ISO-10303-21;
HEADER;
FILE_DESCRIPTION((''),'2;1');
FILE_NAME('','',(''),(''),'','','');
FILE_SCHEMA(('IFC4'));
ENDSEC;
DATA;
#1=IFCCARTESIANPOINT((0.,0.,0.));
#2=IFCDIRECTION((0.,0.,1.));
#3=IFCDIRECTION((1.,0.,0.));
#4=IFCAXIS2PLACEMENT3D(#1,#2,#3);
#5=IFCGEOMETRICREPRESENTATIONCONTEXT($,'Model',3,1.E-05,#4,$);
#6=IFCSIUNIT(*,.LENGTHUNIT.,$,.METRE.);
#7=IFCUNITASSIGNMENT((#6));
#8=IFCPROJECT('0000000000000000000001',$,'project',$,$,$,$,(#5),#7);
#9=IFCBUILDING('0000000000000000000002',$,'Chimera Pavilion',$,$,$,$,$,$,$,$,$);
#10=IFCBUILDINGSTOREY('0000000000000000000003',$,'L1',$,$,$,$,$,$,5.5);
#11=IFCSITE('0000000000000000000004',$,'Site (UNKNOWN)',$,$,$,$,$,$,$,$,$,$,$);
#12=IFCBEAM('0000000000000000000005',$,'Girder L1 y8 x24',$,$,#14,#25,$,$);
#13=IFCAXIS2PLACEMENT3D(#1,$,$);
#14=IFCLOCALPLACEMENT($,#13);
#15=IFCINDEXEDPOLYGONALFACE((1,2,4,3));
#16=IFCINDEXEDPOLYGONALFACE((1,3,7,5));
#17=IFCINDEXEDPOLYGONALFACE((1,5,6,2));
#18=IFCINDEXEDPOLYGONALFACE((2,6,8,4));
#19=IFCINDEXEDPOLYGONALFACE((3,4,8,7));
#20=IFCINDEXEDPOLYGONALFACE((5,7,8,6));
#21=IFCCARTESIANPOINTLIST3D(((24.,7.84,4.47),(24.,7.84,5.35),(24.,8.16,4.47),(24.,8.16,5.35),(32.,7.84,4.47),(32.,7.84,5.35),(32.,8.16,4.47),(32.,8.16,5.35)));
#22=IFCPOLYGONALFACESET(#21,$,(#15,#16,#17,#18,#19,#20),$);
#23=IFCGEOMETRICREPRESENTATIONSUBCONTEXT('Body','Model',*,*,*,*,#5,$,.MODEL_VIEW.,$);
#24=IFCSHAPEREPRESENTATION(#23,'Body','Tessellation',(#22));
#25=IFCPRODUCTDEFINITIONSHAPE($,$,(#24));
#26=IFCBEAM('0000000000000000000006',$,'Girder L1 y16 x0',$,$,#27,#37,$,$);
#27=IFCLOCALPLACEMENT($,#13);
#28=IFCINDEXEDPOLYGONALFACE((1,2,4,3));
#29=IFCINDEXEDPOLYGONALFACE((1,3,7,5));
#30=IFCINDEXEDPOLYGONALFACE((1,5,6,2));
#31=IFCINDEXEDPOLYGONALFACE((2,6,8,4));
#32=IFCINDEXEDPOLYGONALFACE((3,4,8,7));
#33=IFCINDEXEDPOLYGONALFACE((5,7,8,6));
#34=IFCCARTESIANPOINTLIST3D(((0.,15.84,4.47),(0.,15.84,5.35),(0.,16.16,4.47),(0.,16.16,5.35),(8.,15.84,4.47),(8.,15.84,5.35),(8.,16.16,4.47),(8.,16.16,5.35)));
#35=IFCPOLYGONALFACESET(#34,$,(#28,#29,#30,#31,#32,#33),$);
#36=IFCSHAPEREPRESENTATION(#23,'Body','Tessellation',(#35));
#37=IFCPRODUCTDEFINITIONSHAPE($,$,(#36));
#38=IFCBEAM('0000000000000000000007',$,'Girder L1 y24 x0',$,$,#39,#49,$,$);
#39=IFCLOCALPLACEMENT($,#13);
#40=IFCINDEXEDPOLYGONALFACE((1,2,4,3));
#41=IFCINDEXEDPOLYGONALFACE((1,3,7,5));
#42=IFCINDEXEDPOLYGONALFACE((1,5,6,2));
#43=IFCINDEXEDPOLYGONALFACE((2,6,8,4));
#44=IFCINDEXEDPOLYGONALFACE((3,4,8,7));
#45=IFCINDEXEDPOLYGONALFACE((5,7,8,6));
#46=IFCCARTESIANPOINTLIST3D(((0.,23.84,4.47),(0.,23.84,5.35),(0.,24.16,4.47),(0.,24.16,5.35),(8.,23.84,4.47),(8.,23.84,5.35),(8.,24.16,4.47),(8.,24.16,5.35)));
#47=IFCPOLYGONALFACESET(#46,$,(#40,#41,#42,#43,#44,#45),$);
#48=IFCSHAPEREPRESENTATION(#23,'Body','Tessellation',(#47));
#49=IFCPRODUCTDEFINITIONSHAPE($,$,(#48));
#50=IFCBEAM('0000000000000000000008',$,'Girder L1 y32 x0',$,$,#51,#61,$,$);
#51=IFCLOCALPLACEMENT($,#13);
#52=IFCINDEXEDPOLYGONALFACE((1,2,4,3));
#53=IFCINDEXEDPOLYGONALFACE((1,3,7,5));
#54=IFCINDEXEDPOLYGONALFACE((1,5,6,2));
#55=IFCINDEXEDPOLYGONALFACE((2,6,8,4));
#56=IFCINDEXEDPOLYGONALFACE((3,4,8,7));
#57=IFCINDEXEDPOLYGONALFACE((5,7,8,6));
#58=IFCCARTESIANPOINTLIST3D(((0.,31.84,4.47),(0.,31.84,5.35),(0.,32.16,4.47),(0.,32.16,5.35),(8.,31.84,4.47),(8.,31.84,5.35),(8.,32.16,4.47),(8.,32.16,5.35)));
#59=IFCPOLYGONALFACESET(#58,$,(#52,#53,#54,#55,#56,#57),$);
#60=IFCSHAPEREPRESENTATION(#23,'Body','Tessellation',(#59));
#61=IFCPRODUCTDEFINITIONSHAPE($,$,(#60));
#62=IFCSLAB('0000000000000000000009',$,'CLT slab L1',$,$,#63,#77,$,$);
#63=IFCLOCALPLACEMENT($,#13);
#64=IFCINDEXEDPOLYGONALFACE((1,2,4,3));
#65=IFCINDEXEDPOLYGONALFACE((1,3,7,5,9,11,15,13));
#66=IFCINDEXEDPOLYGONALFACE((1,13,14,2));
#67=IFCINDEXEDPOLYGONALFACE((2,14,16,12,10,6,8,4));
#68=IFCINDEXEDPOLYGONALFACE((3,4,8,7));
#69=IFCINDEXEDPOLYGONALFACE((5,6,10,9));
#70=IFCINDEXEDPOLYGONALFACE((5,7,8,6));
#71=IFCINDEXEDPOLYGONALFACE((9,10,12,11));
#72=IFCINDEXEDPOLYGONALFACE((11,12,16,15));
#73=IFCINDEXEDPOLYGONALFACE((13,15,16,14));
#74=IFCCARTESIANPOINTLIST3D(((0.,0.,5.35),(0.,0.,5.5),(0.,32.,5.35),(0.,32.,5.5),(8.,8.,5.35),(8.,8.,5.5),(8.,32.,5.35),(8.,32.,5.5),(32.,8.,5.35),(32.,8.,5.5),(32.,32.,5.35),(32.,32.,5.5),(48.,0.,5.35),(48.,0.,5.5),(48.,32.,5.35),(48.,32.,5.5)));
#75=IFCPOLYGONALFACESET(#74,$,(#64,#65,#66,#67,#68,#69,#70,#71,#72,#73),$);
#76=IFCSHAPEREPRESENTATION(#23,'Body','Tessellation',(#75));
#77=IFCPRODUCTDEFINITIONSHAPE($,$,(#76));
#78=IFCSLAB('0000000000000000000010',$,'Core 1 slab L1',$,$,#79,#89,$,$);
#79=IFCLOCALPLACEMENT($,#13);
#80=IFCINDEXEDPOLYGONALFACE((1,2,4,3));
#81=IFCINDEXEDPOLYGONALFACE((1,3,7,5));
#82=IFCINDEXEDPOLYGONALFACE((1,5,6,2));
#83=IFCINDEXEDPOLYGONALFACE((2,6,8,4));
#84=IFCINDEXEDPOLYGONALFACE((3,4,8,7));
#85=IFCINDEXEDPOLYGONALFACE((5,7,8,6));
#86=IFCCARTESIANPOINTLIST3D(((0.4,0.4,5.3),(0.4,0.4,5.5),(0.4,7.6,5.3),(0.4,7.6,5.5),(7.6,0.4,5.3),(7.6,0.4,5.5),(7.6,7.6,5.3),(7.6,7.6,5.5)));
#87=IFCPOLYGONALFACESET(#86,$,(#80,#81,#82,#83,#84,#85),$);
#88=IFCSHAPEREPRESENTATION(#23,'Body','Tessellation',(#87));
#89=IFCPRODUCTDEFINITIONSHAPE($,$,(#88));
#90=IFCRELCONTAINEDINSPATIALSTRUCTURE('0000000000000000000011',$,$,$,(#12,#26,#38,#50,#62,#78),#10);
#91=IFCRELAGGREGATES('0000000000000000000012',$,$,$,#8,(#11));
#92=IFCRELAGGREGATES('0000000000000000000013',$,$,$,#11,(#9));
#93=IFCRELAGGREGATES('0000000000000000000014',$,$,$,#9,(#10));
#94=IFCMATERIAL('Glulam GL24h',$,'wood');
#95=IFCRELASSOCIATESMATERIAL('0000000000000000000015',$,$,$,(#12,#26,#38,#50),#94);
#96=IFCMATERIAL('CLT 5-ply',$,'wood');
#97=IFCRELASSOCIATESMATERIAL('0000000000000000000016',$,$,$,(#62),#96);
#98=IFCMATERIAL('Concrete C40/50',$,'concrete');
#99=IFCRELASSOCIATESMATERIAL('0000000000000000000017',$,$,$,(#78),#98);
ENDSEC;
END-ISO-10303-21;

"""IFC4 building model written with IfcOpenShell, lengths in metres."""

from ifc_helpers import new_model, si_unit, frame, origin_with_axes, place, context, subcontext, project, spatial, polyline, rectangle, outline, extrude, material, element, save


model = new_model("IFC4")

# Units and contexts
model_context = context("Model", 3, precision=1e-05, world=origin_with_axes())
body_context = subcontext(model_context, "Body", "Model", "MODEL_VIEW")
ifc_project = project(units=[si_unit("LENGTHUNIT", "METRE")], contexts=[model_context])

# Site, building, storey
site = spatial("IfcSite", under=ifc_project, Name="Site (UNKNOWN)")
building = spatial("IfcBuilding", under=site, Name="Chimera Pavilion")
storey = spatial("IfcBuildingStorey", under=building, Name="L1", Elevation=5.5)

# Beams
ifc_material_1 = material(Name="Glulam GL24h", Category="wood")
for number, where, z_axis, x_axis, name in (
    (1, (24.0, 8.0, 4.91), (1.0, 0.0, 0.0), (0.0, -1.0, 0.0), "Girder L1 y8 x24"),
    (2, (0.0, 16.0, 4.91), (1.0, 0.0, 0.0), (0.0, -1.0, 0.0), "Girder L1 y16 x0"),
    (3, (0.0, 24.0, 4.91), (1.0, 0.0, 0.0), (0.0, -1.0, 0.0), "Girder L1 y24 x0"),
    (4, (0.0, 32.0, 4.91), (1.0, 0.0, 0.0), (0.0, -1.0, 0.0), "Girder L1 y32 x0"),
):
    element("IfcBeam", number, at=place(None, frame(where, z_axis=z_axis, x_axis=x_axis)), inside=storey, material=ifc_material_1, Name=name, context=body_context, shape_type="SweptSolid", body=[
        extrude(rectangle(XDim=0.32, YDim=0.88), origin_with_axes(), (0.0, 0.0, 1.0), 8.0),
    ])

# Slabs
ifc_material_2 = material(Name="CLT 5-ply", Category="wood")
slab_1_placement = place(None, frame((0.0, 0.0, 5.35), z_axis=(0.0, 0.0, 1.0), x_axis=(1.0, 0.0, 0.0)))
element("IfcSlab", 5, at=slab_1_placement, inside=storey, material=ifc_material_2, Name="CLT slab L1", context=body_context, shape_type="SweptSolid", body=[
    extrude(outline(polyline([(0.0, 0.0), (48.0, 0.0), (48.0, 32.0), (32.0, 32.0), (32.0, 8.0), (8.0, 8.0), (8.0, 32.0), (0.0, 32.0), (0.0, 0.0)])), origin_with_axes(), (0.0, 0.0, 1.0), 0.15),
])
ifc_material_3 = material(Name="Concrete C40/50", Category="concrete")
slab_2_placement = place(None, frame((4.0, 4.0, 5.3), z_axis=(0.0, 0.0, 1.0), x_axis=(1.0, 0.0, 0.0)))
element("IfcSlab", 6, at=slab_2_placement, inside=storey, material=ifc_material_3, Name="Core 1 slab L1", context=body_context, shape_type="SweptSolid", body=[
    extrude(rectangle(XDim=7.2, YDim=7.2), origin_with_axes(), (0.0, 0.0, 1.0), 0.2),
])

save(model, "model.ifc")
